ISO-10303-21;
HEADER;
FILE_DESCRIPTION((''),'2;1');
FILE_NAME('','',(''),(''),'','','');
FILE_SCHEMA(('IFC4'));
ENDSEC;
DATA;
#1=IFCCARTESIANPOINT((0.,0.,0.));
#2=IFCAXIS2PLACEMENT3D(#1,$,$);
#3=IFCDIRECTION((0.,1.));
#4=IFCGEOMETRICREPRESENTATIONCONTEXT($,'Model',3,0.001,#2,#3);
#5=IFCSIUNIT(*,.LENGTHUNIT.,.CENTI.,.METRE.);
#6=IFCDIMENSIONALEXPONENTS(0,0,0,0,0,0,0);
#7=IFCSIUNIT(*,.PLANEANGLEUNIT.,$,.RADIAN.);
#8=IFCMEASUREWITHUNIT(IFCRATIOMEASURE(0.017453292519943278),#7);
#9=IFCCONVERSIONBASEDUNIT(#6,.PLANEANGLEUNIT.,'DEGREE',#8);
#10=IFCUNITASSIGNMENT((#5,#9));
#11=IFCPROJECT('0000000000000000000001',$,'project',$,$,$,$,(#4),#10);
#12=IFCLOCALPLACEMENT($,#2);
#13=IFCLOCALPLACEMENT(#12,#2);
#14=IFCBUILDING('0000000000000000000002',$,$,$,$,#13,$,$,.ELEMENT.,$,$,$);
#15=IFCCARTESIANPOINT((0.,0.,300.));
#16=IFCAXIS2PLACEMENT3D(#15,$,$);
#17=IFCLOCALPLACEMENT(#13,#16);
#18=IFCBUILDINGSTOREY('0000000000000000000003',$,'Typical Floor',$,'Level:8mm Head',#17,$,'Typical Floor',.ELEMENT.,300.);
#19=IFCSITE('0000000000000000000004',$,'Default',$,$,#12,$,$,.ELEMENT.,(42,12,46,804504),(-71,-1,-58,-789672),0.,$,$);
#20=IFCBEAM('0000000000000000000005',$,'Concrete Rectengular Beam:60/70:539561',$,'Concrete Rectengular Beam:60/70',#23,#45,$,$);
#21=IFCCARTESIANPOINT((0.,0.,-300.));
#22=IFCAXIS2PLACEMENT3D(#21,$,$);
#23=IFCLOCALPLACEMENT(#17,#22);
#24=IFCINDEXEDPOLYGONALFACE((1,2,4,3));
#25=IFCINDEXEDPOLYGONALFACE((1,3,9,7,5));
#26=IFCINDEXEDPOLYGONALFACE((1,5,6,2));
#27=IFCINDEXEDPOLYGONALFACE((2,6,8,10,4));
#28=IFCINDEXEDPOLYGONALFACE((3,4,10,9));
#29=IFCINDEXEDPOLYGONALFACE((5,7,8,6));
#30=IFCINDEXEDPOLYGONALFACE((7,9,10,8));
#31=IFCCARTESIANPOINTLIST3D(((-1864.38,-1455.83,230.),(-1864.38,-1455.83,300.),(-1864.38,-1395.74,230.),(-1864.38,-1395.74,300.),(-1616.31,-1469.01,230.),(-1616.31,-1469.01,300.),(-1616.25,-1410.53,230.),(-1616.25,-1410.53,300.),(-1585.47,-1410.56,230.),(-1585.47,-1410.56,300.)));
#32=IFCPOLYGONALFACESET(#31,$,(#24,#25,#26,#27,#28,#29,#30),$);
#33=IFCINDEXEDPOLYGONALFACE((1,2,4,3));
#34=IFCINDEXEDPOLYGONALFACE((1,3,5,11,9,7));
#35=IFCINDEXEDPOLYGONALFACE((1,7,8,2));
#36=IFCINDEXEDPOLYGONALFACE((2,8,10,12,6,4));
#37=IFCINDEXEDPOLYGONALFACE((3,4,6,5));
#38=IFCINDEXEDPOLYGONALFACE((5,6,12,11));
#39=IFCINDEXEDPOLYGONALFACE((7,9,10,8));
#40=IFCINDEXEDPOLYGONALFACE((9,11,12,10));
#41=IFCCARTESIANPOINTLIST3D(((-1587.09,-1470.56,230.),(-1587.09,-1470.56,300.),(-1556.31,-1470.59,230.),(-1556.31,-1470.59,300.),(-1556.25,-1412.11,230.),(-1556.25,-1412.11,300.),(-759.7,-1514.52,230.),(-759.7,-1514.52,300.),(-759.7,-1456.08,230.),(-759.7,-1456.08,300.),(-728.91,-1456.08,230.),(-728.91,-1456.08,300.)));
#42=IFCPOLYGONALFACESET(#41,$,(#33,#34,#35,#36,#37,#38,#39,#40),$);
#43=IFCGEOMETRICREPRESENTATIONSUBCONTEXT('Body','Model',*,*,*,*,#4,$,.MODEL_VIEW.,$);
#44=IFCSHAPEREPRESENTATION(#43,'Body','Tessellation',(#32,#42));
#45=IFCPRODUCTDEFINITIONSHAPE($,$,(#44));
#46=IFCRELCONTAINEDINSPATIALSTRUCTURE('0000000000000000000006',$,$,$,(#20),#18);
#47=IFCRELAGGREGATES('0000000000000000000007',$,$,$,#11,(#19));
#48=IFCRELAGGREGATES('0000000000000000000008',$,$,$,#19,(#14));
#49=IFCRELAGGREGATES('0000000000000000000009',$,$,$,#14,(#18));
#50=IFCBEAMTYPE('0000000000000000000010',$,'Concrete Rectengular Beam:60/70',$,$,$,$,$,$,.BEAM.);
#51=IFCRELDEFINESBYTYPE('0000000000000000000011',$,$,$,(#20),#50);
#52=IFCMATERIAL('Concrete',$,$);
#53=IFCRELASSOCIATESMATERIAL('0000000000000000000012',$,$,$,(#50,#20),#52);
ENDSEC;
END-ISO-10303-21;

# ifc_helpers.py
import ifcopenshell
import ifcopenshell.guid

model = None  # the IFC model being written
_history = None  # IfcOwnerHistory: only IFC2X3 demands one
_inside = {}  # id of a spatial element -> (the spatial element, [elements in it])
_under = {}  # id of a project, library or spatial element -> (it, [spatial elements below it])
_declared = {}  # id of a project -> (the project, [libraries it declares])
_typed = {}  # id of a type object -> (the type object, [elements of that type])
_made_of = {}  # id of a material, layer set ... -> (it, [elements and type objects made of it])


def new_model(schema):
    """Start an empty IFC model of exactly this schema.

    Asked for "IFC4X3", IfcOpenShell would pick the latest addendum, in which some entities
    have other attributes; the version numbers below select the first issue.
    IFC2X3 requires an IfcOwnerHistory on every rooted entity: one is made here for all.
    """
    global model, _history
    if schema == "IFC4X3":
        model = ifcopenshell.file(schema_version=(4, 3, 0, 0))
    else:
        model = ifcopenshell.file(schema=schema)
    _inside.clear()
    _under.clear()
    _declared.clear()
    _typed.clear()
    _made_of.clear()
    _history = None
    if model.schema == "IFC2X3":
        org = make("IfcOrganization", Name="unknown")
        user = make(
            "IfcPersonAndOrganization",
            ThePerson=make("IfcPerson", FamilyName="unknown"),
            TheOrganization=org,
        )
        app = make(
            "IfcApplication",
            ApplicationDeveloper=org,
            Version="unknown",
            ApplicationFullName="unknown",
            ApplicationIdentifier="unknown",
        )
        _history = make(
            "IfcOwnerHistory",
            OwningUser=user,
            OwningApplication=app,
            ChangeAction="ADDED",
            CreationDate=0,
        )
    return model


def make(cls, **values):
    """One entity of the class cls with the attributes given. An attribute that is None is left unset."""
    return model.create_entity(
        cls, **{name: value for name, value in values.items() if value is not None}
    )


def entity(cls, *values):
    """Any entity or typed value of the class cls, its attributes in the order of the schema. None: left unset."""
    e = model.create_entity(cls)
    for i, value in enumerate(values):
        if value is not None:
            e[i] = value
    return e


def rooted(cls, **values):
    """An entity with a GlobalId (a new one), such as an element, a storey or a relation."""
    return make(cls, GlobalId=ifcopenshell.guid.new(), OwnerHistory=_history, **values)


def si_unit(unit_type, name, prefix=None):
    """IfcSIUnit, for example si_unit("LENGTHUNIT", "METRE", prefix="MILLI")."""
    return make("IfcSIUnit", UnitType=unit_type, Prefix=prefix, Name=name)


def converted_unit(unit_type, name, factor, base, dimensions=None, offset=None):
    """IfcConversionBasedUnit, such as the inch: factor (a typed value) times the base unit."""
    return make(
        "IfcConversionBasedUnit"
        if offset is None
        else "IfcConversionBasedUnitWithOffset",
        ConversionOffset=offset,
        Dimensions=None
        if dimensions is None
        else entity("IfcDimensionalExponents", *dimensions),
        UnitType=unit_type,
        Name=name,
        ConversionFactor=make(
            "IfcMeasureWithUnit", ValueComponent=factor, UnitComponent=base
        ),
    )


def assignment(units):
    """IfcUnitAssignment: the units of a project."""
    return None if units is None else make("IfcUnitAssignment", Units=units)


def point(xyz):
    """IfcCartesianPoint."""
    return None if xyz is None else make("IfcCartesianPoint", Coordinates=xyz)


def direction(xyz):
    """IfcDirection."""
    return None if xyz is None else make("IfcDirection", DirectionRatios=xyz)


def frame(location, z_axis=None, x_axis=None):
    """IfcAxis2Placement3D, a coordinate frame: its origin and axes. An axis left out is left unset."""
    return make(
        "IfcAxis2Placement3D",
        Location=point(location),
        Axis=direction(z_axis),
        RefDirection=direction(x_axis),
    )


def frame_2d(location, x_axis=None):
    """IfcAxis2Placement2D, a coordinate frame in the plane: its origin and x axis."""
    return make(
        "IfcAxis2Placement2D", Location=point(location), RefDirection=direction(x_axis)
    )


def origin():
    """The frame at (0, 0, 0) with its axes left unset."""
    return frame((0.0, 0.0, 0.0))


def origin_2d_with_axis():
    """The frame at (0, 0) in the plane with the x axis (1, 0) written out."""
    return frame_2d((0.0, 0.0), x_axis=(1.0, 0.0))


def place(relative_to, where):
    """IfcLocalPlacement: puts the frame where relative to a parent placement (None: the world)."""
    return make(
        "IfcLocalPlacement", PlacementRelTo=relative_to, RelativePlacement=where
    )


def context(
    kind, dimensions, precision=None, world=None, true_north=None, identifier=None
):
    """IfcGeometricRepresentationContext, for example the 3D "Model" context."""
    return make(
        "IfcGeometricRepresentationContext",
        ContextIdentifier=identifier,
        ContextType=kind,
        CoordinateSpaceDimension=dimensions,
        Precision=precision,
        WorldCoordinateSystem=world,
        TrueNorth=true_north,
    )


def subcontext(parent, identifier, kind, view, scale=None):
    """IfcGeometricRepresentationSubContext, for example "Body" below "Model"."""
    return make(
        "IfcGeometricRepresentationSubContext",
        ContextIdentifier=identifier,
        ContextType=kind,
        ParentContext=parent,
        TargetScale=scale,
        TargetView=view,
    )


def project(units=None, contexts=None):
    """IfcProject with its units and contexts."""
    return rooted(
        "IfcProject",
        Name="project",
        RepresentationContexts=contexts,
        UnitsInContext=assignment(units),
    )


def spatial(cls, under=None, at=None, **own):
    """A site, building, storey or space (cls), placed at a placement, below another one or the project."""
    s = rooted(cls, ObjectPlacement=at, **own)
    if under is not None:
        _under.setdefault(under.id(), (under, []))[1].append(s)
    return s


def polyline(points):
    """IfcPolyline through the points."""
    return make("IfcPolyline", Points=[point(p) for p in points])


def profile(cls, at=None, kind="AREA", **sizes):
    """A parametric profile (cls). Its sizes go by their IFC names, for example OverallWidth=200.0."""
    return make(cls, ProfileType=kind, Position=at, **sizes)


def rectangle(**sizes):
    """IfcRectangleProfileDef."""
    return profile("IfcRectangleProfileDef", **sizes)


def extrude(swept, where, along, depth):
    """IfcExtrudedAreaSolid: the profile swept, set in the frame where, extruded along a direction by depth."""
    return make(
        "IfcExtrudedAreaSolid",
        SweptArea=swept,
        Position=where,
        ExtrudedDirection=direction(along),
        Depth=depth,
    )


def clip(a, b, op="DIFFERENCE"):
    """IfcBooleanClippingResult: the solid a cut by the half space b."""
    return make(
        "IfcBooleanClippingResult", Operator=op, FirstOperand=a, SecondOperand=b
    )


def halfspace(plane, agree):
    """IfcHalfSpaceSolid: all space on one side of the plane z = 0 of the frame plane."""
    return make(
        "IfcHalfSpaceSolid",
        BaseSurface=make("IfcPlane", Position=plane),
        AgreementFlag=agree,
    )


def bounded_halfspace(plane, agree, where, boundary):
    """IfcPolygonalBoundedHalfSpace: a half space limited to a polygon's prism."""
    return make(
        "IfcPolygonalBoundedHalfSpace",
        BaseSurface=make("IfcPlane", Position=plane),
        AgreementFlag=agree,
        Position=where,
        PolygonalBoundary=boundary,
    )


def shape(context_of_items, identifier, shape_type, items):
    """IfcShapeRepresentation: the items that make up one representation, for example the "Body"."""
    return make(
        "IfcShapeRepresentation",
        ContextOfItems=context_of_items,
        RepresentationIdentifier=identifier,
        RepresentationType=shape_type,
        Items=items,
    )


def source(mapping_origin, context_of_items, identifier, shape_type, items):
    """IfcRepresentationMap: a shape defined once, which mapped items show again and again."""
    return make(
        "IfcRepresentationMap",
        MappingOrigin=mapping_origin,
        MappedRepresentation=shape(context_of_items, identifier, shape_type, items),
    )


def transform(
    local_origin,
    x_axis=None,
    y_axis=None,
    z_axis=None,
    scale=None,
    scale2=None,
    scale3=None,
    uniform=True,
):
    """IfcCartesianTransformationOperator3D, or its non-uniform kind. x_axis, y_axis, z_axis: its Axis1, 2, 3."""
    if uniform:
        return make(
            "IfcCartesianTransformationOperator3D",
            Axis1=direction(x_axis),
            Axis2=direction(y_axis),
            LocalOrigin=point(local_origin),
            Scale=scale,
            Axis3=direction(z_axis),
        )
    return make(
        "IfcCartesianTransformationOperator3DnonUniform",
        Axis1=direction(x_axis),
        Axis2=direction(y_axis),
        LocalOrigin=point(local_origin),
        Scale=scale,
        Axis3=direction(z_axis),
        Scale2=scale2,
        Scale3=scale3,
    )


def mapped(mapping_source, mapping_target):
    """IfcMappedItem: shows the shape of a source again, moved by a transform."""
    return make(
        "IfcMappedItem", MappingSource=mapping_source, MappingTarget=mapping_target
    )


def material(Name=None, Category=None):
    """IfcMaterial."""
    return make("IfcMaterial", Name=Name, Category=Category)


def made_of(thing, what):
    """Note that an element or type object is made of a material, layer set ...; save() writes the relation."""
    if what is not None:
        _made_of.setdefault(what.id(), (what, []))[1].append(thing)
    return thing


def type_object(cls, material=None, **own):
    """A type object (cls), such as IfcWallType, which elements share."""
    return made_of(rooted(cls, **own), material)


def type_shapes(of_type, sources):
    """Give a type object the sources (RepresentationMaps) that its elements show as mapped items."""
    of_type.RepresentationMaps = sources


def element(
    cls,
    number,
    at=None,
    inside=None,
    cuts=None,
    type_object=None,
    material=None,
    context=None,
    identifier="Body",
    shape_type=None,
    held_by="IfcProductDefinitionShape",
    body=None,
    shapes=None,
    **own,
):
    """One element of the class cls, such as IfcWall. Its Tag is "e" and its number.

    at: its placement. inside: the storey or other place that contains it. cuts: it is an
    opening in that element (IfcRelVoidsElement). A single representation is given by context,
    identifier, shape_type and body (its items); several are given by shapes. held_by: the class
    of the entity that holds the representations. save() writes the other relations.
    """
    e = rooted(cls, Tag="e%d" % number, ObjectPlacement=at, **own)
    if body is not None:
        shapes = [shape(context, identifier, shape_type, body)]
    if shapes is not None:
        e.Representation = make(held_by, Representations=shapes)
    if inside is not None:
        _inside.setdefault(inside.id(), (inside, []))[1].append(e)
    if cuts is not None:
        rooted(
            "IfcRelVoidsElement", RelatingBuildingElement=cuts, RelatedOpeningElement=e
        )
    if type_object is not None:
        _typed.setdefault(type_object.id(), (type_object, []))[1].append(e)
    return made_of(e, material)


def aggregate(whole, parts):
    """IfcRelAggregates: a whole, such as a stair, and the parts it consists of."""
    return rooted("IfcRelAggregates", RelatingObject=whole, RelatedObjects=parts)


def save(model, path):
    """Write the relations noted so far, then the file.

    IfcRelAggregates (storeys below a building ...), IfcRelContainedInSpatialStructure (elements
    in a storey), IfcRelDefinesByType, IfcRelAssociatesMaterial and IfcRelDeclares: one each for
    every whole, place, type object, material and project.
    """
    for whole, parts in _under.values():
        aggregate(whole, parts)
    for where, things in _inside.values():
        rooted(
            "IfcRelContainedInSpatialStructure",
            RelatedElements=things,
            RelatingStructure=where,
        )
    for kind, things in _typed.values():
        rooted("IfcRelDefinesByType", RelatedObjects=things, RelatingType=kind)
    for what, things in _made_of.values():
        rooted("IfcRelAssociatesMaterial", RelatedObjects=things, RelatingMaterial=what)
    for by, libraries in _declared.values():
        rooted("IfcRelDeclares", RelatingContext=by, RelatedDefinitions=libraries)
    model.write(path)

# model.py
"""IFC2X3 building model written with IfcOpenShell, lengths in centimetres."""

from ifc_helpers import new_model, entity, si_unit, converted_unit, direction, frame, frame_2d, origin, origin_2d_with_axis, place, context, subcontext, project, spatial, polyline, rectangle, extrude, clip, halfspace, bounded_halfspace, source, transform, mapped, material, type_object, type_shapes, element, save


model = new_model("IFC2X3")

# Units and contexts
model_context = context("Model", 3, precision=0.001, world=origin(), true_north=direction((0.0, 1.0)))
body_context = subcontext(model_context, "Body", "Model", "MODEL_VIEW")
ifc_project = project(units=[si_unit("LENGTHUNIT", "METRE", prefix="CENTI"), converted_unit("PLANEANGLEUNIT", "DEGREE", entity("IfcRatioMeasure", 0.017453292519943278), si_unit("PLANEANGLEUNIT", "RADIAN"), dimensions=[0, 0, 0, 0, 0, 0, 0])], contexts=[model_context])

# Site, building, storey
site_placement = place(None, origin())
site = spatial("IfcSite", under=ifc_project, at=site_placement, Name="Default", CompositionType="ELEMENT", RefLatitude=(42, 12, 46, 804504), RefLongitude=(-71, -1, -58, -789672), RefElevation=0.0)
building_placement = place(site_placement, origin())
building = spatial("IfcBuilding", under=site, at=building_placement, CompositionType="ELEMENT")
storey_placement = place(building_placement, frame((0.0, 0.0, 300.0)))
storey = spatial("IfcBuildingStorey", under=building, at=storey_placement, Name="Typical Floor", ObjectType="Level:8mm Head", LongName="Typical Floor", CompositionType="ELEMENT", Elevation=300.0)

# Beam
ifc_material = material(Name="Concrete")
beam_type_1 = type_object("IfcBeamType", Name="Concrete Rectengular Beam:60/70", PredefinedType="BEAM", material=ifc_material)
shared_shape_1 = source(origin(), body_context, "Body", "SweptSolid", [
    clip(clip(clip(extrude(rectangle(XDim=70.0, YDim=60.0, at=origin_2d_with_axis()), frame((-1587.06, -1440.52, 265.0), z_axis=(-0.998591, 0.053061, 0.0), x_axis=(0.0, 0.0, 1.0)), (0.0, 0.0, 1.0), 279.3), halfspace(frame((-1864.38, -1458.85, 300.0), z_axis=(-1.0, 0.0, 0.0), x_axis=(0.0, 1.0, 0.0)), False)), bounded_halfspace(frame((-1556.25, -1410.59, 300.0), z_axis=(-0.001075, -0.999999, 0.0), x_axis=(0.0, 0.0, -1.0)), False, frame((-1587.06, -1440.52, 265.0), z_axis=(-0.998591, 0.053061, 0.0), x_axis=(0.0, 0.0, 1.0)), polyline([(35.0, 28.4), (-35.0, 28.4), (-35.0, 30.0), (35.0, 30.0), (35.0, 28.4)]))), bounded_halfspace(frame((-1616.25, -1410.53, 300.0), z_axis=(0.999999, -0.001075, 0.0), x_axis=(0.0, 0.0, -1.0)), False, frame((-1587.06, -1440.52, 265.0), z_axis=(-0.998591, 0.053061, 0.0), x_axis=(0.0, 0.0, 1.0)), polyline([(-35.0, 28.4), (35.0, 28.4), (35.0, -30.0), (-35.0, -30.0), (-35.0, 28.4)]))),
    clip(clip(clip(clip(extrude(rectangle(XDim=70.0, YDim=60.0, at=frame_2d((0.0, 0.0), x_axis=(1.0, 0.0))), frame((-730.5, -1486.03, 265.0), z_axis=(-0.998591, 0.053061, 0.0), x_axis=(0.0, 0.0, 1.0)), (0.0, 0.0, 1.0), 856.21), bounded_halfspace(frame((-1556.31, -1470.59, 300.0), z_axis=(-0.999999, 0.001075, 0.0), x_axis=(0.0, 0.0, -1.0)), False, frame((-730.5, -1486.03, 265.0), z_axis=(-0.998591, 0.053061, 0.0), x_axis=(0.0, 0.0, 1.0)), polyline([(-35.0, -28.4), (35.0, -28.4), (35.0, 30.0), (10.0, 30.0), (-35.0, 30.0), (-35.0, -28.4)]))), bounded_halfspace(frame((-1616.31, -1470.53, 300.0), z_axis=(0.001075, 0.999999, 0.0), x_axis=(0.0, 0.0, -1.0)), False, frame((-730.5, -1486.03, 265.0), z_axis=(-0.998591, 0.053061, 0.0), x_axis=(0.0, 0.0, 1.0)), polyline([(35.0, -28.4), (-35.0, -28.4), (-35.0, -30.0), (35.0, -30.0), (35.0, -28.4)]))), bounded_halfspace(frame((-699.7, -1456.08, 300.0), z_axis=(0.0, -1.0, 0.0), x_axis=(0.0, 0.0, -1.0)), False, frame((-730.5, -1486.03, 265.0), z_axis=(-0.998591, 0.053061, 0.0), x_axis=(0.0, 0.0, 1.0)), polyline([(35.0, 28.37), (-35.0, 28.37), (-35.0, 30.0), (35.0, 30.0), (35.0, 28.37)]))), bounded_halfspace(frame((-759.7, -1456.08, 300.0), z_axis=(1.0, 0.0, 0.0), x_axis=(0.0, 0.0, -1.0)), False, frame((-730.5, -1486.03, 265.0), z_axis=(-0.998591, 0.053061, 0.0), x_axis=(0.0, 0.0, 1.0)), polyline([(-35.0, 28.37), (35.0, 28.37), (35.0, -30.0), (-35.0, -30.0), (-35.0, 28.37)]))),
])
type_shapes(beam_type_1, [shared_shape_1])
beam_1_placement = place(storey_placement, frame((0.0, 0.0, -300.0)))
element("IfcBeam", 1, at=beam_1_placement, inside=storey, type_object=beam_type_1, material=ifc_material, Name="Concrete Rectengular Beam:60/70:539561", ObjectType="Concrete Rectengular Beam:60/70", context=body_context, shape_type="MappedRepresentation", body=[
    mapped(shared_shape_1, transform((0.0, 0.0, 0.0), scale=1.0)),
])

save(model, "model.ifc")
